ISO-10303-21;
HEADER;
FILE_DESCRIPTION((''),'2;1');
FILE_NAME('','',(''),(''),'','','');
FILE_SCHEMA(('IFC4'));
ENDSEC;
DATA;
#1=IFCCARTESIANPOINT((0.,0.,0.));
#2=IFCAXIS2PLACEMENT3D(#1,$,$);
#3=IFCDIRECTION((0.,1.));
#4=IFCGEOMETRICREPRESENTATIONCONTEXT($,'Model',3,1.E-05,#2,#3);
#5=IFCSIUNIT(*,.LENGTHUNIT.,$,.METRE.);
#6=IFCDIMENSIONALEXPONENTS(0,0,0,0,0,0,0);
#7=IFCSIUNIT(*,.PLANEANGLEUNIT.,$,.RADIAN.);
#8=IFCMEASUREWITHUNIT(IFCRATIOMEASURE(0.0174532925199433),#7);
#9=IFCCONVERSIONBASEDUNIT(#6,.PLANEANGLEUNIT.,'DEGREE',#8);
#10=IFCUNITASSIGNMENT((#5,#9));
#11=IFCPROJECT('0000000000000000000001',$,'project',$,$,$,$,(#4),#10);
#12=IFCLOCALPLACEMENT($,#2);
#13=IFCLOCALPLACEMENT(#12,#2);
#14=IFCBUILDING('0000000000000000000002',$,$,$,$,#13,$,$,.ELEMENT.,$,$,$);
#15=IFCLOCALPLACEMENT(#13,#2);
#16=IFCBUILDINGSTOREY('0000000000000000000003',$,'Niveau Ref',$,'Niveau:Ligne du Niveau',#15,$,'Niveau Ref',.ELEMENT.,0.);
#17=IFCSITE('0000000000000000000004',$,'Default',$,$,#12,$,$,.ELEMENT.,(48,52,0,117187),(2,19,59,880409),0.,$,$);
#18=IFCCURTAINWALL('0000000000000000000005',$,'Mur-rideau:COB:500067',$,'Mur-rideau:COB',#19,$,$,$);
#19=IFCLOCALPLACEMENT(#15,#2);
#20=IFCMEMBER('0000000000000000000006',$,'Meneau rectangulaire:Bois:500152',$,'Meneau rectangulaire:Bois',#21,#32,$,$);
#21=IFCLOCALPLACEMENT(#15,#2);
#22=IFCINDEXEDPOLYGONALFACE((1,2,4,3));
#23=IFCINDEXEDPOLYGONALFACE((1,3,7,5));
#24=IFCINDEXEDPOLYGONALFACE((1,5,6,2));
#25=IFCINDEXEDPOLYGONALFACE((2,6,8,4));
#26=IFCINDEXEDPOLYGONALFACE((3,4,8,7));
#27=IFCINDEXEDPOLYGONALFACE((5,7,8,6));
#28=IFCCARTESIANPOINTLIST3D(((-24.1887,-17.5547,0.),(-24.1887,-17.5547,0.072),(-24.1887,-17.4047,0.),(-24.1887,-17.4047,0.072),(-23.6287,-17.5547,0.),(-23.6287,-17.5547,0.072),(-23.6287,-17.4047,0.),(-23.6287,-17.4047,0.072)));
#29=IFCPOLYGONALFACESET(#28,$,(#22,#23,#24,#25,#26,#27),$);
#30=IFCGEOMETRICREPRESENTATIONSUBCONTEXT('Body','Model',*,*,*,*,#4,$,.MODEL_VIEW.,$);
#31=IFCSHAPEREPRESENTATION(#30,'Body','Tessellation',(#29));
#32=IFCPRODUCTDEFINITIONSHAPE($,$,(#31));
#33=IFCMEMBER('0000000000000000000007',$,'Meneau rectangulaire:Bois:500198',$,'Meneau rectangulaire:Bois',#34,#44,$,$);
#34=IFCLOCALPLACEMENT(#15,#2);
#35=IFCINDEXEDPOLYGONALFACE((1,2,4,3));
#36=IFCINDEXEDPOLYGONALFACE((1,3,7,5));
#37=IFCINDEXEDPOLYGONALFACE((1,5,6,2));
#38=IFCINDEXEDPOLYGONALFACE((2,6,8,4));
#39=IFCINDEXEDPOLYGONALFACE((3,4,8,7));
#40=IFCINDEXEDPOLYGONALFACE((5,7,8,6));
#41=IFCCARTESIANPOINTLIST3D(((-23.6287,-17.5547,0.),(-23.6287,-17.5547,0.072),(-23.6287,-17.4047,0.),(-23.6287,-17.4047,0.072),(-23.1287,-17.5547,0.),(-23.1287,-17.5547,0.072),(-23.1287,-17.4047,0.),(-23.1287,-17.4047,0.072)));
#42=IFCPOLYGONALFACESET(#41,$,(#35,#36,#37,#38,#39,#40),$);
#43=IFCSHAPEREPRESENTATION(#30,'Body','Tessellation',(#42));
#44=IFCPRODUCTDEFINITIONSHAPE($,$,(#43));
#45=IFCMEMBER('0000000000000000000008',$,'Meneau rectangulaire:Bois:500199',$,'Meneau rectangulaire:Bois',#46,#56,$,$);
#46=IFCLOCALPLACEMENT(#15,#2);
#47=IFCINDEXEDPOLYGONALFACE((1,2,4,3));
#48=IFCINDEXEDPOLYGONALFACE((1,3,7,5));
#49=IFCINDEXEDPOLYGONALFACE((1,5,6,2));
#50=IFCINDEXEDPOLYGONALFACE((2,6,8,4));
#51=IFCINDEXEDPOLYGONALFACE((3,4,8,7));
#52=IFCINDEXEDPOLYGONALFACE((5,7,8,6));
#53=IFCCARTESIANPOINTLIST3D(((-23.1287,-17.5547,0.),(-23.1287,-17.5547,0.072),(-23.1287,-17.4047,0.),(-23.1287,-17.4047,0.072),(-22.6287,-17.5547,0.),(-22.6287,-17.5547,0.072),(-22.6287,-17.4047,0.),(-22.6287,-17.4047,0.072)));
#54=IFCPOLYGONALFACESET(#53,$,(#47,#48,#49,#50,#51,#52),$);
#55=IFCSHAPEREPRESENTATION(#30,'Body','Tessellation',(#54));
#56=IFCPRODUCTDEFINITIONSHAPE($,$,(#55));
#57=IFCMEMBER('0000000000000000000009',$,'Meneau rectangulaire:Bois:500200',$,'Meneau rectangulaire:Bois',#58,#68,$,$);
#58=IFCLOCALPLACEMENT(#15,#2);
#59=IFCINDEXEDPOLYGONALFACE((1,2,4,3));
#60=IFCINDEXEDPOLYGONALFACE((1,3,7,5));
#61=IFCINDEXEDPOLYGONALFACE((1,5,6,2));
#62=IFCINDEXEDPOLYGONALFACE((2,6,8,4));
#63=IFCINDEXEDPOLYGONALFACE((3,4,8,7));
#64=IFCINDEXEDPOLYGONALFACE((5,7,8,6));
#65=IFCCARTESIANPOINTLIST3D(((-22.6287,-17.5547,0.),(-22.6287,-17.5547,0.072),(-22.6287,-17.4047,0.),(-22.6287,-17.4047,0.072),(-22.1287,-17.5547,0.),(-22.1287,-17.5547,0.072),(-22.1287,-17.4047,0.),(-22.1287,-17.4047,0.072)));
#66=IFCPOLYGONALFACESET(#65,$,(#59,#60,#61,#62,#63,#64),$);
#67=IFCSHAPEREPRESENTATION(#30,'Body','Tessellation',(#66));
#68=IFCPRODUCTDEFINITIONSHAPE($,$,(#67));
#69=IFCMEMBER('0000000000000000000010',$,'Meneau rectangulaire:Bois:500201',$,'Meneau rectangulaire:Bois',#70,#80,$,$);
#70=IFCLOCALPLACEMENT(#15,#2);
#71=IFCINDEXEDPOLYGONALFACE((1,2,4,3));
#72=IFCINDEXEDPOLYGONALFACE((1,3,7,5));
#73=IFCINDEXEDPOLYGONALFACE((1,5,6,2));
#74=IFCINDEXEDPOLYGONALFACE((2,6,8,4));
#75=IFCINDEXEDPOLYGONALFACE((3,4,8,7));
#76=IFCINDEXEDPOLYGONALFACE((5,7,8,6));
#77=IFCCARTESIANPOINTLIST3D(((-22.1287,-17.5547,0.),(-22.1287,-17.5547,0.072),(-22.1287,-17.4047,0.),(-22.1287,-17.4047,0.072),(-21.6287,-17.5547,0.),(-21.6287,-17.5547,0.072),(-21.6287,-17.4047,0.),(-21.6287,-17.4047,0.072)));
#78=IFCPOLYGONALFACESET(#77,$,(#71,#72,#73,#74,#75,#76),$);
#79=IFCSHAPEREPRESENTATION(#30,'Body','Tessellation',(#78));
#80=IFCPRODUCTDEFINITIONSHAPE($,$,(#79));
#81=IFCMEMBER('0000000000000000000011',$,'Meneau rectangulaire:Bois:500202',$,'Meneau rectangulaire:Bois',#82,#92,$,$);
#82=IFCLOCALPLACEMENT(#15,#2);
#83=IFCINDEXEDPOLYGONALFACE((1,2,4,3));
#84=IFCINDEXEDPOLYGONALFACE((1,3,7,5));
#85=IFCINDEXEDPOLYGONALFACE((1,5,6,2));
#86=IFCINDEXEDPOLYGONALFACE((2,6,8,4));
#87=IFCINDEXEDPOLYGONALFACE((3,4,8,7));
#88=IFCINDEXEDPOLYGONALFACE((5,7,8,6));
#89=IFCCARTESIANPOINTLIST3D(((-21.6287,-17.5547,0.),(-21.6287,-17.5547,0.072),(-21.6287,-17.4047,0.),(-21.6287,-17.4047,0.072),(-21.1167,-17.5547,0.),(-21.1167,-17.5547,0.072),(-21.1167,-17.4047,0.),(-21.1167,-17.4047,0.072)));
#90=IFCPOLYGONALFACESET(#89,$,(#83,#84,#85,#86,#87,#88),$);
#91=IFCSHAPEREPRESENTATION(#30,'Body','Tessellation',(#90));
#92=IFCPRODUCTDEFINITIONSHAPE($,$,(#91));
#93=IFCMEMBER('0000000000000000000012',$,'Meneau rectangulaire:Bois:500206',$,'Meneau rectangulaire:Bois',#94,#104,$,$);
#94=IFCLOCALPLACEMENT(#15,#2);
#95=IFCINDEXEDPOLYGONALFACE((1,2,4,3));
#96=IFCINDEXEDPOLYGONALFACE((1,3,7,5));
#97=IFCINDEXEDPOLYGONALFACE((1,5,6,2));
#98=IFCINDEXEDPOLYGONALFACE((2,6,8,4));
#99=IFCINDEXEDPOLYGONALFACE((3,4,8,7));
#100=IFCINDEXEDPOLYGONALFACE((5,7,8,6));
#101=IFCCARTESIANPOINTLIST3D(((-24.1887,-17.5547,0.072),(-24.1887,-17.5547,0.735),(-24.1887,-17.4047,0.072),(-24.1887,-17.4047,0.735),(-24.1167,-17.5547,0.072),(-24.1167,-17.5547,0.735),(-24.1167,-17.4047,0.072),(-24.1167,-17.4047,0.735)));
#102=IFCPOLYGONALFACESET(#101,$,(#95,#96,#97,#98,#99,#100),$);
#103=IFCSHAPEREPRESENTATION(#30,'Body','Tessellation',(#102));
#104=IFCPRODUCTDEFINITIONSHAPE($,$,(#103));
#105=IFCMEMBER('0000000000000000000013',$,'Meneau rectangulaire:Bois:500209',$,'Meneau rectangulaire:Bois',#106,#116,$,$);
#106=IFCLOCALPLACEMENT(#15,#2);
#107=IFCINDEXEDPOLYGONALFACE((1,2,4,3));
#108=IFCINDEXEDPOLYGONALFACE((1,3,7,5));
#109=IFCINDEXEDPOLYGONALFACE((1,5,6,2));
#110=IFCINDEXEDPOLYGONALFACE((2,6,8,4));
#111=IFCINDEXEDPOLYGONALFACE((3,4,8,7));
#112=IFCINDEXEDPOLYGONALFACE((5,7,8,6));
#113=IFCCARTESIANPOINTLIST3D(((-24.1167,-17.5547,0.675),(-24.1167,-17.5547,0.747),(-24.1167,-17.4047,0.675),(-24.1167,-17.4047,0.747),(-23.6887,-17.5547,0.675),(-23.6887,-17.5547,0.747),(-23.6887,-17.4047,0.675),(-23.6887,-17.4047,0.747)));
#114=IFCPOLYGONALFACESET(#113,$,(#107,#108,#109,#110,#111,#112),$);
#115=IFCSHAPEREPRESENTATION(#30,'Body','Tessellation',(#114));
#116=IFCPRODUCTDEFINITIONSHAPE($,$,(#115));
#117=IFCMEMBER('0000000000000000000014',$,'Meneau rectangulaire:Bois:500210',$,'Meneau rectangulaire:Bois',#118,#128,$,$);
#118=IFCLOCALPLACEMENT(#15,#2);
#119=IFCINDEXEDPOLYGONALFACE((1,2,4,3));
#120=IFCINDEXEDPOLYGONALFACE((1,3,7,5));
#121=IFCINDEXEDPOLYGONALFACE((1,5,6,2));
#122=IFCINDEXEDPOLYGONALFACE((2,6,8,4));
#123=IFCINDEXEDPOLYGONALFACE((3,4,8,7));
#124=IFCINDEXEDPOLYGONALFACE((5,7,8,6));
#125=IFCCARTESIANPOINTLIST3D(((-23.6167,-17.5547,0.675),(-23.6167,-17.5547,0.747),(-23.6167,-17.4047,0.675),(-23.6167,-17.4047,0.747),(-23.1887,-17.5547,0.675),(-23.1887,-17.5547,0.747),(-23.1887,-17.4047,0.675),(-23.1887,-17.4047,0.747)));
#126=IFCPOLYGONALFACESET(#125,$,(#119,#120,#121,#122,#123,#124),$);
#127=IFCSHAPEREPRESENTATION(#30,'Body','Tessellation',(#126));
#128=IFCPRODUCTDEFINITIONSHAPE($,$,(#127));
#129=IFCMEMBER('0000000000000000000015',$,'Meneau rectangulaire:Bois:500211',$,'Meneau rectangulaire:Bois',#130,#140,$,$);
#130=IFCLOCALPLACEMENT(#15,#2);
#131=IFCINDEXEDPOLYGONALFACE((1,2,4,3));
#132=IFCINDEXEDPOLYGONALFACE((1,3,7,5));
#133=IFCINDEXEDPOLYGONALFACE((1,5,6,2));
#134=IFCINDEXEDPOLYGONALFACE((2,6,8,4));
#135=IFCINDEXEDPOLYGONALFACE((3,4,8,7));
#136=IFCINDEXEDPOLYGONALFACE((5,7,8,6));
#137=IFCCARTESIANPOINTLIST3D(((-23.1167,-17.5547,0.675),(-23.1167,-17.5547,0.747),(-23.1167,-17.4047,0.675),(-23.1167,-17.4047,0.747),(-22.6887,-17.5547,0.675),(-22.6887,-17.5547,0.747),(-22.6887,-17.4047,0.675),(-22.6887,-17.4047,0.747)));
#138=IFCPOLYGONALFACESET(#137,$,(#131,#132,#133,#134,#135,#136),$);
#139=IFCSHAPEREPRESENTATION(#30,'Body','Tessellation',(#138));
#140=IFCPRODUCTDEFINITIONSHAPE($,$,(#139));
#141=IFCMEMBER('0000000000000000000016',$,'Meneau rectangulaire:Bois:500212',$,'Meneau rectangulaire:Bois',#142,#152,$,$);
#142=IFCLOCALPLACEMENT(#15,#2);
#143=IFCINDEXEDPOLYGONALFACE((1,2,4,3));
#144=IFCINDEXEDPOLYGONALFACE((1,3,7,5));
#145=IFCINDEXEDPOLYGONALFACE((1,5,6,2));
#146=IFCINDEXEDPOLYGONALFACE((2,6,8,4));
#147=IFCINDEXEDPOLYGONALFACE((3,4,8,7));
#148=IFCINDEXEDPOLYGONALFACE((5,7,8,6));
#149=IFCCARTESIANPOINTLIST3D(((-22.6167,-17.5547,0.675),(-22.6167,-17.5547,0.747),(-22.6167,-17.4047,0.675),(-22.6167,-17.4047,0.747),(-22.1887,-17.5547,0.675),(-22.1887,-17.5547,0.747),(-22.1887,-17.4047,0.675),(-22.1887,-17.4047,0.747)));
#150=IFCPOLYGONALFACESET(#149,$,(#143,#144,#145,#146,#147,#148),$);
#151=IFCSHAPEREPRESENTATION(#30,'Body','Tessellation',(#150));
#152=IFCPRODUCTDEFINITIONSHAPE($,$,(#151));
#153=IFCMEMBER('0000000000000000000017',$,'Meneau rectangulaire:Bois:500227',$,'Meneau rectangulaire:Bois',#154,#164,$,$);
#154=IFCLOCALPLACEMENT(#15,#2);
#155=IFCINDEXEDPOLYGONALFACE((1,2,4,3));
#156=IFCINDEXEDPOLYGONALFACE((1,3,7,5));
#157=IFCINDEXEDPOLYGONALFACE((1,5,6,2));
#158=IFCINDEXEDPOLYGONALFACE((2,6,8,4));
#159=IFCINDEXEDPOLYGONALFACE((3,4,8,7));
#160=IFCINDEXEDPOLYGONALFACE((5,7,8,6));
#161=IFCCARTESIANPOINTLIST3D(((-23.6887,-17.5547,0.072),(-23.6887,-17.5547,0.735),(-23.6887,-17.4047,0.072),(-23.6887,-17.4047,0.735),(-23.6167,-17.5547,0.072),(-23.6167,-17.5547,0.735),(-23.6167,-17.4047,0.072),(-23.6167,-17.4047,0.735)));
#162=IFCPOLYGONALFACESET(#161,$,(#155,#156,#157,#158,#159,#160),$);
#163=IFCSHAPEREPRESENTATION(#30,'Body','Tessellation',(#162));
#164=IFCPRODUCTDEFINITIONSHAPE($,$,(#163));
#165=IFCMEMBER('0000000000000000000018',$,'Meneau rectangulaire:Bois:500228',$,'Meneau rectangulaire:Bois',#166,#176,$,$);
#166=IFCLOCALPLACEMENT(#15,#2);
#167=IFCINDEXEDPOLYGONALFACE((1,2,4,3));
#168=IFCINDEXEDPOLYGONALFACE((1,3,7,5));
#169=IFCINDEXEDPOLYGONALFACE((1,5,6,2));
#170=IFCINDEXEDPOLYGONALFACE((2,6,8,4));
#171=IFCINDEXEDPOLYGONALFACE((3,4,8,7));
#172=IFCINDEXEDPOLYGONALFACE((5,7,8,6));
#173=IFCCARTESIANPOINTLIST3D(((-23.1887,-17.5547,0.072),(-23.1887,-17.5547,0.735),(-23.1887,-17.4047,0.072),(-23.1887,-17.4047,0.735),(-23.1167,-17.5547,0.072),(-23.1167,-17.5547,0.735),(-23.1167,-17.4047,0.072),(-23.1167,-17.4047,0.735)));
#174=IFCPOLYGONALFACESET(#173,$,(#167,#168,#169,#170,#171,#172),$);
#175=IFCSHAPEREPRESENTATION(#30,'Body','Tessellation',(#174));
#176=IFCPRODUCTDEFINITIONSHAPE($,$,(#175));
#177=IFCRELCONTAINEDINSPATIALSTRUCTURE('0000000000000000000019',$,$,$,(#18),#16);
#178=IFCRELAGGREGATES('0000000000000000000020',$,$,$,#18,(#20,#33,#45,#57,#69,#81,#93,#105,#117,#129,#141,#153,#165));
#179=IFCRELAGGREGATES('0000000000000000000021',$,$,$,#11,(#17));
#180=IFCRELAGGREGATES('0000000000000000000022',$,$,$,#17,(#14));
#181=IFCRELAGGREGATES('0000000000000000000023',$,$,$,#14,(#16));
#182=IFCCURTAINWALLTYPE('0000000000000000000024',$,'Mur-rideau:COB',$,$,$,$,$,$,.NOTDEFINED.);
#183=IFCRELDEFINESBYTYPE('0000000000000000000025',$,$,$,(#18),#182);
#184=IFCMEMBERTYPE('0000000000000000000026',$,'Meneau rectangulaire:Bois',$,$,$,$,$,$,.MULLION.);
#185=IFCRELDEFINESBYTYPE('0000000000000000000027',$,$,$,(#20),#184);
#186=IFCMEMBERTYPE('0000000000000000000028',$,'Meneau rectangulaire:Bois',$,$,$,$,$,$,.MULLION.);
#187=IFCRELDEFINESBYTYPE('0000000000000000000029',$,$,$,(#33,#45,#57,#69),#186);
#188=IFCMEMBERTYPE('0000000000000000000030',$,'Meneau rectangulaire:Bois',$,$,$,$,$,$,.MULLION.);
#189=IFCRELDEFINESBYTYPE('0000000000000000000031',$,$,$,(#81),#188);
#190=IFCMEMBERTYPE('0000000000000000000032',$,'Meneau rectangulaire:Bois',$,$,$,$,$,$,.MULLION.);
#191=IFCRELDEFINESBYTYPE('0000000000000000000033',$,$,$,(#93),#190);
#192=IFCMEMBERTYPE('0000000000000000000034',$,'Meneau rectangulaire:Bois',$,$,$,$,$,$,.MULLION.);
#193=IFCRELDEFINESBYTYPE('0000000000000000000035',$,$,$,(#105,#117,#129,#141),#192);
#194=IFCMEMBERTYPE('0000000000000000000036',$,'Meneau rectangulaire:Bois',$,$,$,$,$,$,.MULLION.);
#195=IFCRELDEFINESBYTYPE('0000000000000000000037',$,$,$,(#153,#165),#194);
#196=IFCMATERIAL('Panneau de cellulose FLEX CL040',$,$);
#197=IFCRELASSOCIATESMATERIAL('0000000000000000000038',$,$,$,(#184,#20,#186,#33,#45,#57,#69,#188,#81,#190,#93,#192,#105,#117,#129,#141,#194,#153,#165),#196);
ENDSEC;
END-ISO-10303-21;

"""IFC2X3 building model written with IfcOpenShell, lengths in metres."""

from ifc_helpers import new_model, entity, si_unit, converted_unit, direction, frame, origin, origin_2d_with_axis, place, context, subcontext, project, spatial, rectangle, extrude, source, transform, mapped, material, type_object, type_shapes, element, aggregate, save


model = new_model("IFC2X3")

# Units and contexts
model_context = context("Model", 3, precision=1e-05, world=origin(), true_north=direction((0.0, 1.0)))
body_context = subcontext(model_context, "Body", "Model", "MODEL_VIEW")
ifc_project = project(units=[si_unit("LENGTHUNIT", "METRE"), converted_unit("PLANEANGLEUNIT", "DEGREE", entity("IfcRatioMeasure", 0.0174532925199433), si_unit("PLANEANGLEUNIT", "RADIAN"), dimensions=[0, 0, 0, 0, 0, 0, 0])], contexts=[model_context])

# Site, building, storey
site_placement = place(None, origin())
site = spatial("IfcSite", under=ifc_project, at=site_placement, Name="Default", CompositionType="ELEMENT", RefLatitude=(48, 52, 0, 117187), RefLongitude=(2, 19, 59, 880409), RefElevation=0.0)
building_placement = place(site_placement, origin())
building = spatial("IfcBuilding", under=site, at=building_placement, CompositionType="ELEMENT")
storey_placement = place(building_placement, origin())
storey = spatial("IfcBuildingStorey", under=building, at=storey_placement, Name="Niveau Ref", ObjectType="Niveau:Ligne du Niveau", LongName="Niveau Ref", CompositionType="ELEMENT", Elevation=0.0)

# Curtain wall, members
curtain_wall_type_1 = type_object("IfcCurtainWallType", Name="Mur-rideau:COB", PredefinedType="NOTDEFINED")
curtain_wall_1_placement = place(storey_placement, origin())
curtain_wall_1 = element("IfcCurtainWall", 1, at=curtain_wall_1_placement, inside=storey, type_object=curtain_wall_type_1, Name="Mur-rideau:COB:500067", ObjectType="Mur-rideau:COB")
ifc_material_1 = material(Name="Panneau de cellulose FLEX CL040")
member_type_1 = type_object("IfcMemberType", Name="Meneau rectangulaire:Bois", PredefinedType="MULLION", material=ifc_material_1)
shared_shape_1 = source(origin(), body_context, "Body", "SweptSolid", [
    extrude(rectangle(XDim=0.15, YDim=0.072, at=origin_2d_with_axis()), frame((-0.036, 0.0, -0.56), z_axis=(0.0, 0.0, 1.0), x_axis=(0.0, -1.0, 0.0)), (0.0, 0.0, 1.0), 0.56),
])
type_shapes(member_type_1, [shared_shape_1])
member_1_placement = place(storey_placement, frame((-24.1887, -17.4797, 0.0), z_axis=(-1.0, 0.0, 0.0), x_axis=(0.0, 0.0, -1.0)))
member_1 = element("IfcMember", 2, at=member_1_placement, type_object=member_type_1, material=ifc_material_1, Name="Meneau rectangulaire:Bois:500152", ObjectType="Meneau rectangulaire:Bois", context=body_context, shape_type="MappedRepresentation", body=[
    mapped(shared_shape_1, transform((0.0, 0.0, 0.0), scale=1.0)),
])
member_type_2 = type_object("IfcMemberType", Name="Meneau rectangulaire:Bois", PredefinedType="MULLION", material=ifc_material_1)
shared_shape_2 = source(origin(), body_context, "Body", "SweptSolid", [
    extrude(rectangle(XDim=0.15, YDim=0.072, at=origin_2d_with_axis()), frame((-0.036, 0.0, -0.5), z_axis=(0.0, 0.0, 1.0), x_axis=(0.0, -1.0, 0.0)), (0.0, 0.0, 1.0), 0.5),
])
type_shapes(member_type_2, [shared_shape_2])
member_2_placement = place(storey_placement, frame((-23.6287, -17.4797, 0.0), z_axis=(-1.0, 0.0, 0.0), x_axis=(0.0, 0.0, -1.0)))
member_2 = element("IfcMember", 3, at=member_2_placement, type_object=member_type_2, material=ifc_material_1, Name="Meneau rectangulaire:Bois:500198", ObjectType="Meneau rectangulaire:Bois", context=body_context, shape_type="MappedRepresentation", body=[
    mapped(shared_shape_2, transform((0.0, 0.0, 0.0), scale=1.0)),
])
member_3_placement = place(storey_placement, frame((-23.1287, -17.4797, 0.0), z_axis=(-1.0, 0.0, 0.0), x_axis=(0.0, 0.0, -1.0)))
member_3 = element("IfcMember", 4, at=member_3_placement, type_object=member_type_2, material=ifc_material_1, Name="Meneau rectangulaire:Bois:500199", ObjectType="Meneau rectangulaire:Bois", context=body_context, shape_type="MappedRepresentation", body=[
    mapped(shared_shape_2, transform((0.0, 0.0, 0.0), scale=1.0)),
])
member_4_placement = place(storey_placement, frame((-22.6287, -17.4797, 0.0), z_axis=(-1.0, 0.0, 0.0), x_axis=(0.0, 0.0, -1.0)))
member_4 = element("IfcMember", 5, at=member_4_placement, type_object=member_type_2, material=ifc_material_1, Name="Meneau rectangulaire:Bois:500200", ObjectType="Meneau rectangulaire:Bois", context=body_context, shape_type="MappedRepresentation", body=[
    mapped(shared_shape_2, transform((0.0, 0.0, 0.0), scale=1.0)),
])
member_5_placement = place(storey_placement, frame((-22.1287, -17.4797, 0.0), z_axis=(-1.0, 0.0, 0.0), x_axis=(0.0, 0.0, -1.0)))
member_5 = element("IfcMember", 6, at=member_5_placement, type_object=member_type_2, material=ifc_material_1, Name="Meneau rectangulaire:Bois:500201", ObjectType="Meneau rectangulaire:Bois", context=body_context, shape_type="MappedRepresentation", body=[
    mapped(shared_shape_2, transform((0.0, 0.0, 0.0), scale=1.0)),
])
member_type_3 = type_object("IfcMemberType", Name="Meneau rectangulaire:Bois", PredefinedType="MULLION", material=ifc_material_1)
shared_shape_3 = source(origin(), body_context, "Body", "SweptSolid", [
    extrude(rectangle(XDim=0.15, YDim=0.072, at=origin_2d_with_axis()), frame((-0.036, 0.0, -0.512), z_axis=(0.0, 0.0, 1.0), x_axis=(0.0, -1.0, 0.0)), (0.0, 0.0, 1.0), 0.512),
])
type_shapes(member_type_3, [shared_shape_3])
member_6_placement = place(storey_placement, frame((-21.6287, -17.4797, 0.0), z_axis=(-1.0, 0.0, 0.0), x_axis=(0.0, 0.0, -1.0)))
member_6 = element("IfcMember", 7, at=member_6_placement, type_object=member_type_3, material=ifc_material_1, Name="Meneau rectangulaire:Bois:500202", ObjectType="Meneau rectangulaire:Bois", context=body_context, shape_type="MappedRepresentation", body=[
    mapped(shared_shape_3, transform((0.0, 0.0, 0.0), scale=1.0)),
])
member_type_4 = type_object("IfcMemberType", Name="Meneau rectangulaire:Bois", PredefinedType="MULLION", material=ifc_material_1)
shared_shape_4 = source(origin(), body_context, "Body", "SweptSolid", [
    extrude(rectangle(XDim=0.15, YDim=0.072, at=origin_2d_with_axis()), frame((-0.036, 0.0, -0.663), z_axis=(0.0, 0.0, 1.0), x_axis=(0.0, -1.0, 0.0)), (0.0, 0.0, 1.0), 0.663),
])
type_shapes(member_type_4, [shared_shape_4])
member_7_placement = place(storey_placement, frame((-24.1887, -17.4797, 0.735), z_axis=(0.0, 0.0, 1.0), x_axis=(-1.0, 0.0, 0.0)))
member_7 = element("IfcMember", 8, at=member_7_placement, type_object=member_type_4, material=ifc_material_1, Name="Meneau rectangulaire:Bois:500206", ObjectType="Meneau rectangulaire:Bois", context=body_context, shape_type="MappedRepresentation", body=[
    mapped(shared_shape_4, transform((0.0, 0.0, 0.0), scale=1.0)),
])
member_type_5 = type_object("IfcMemberType", Name="Meneau rectangulaire:Bois", PredefinedType="MULLION", material=ifc_material_1)
shared_shape_5 = source(origin(), body_context, "Body", "SweptSolid", [
    extrude(rectangle(XDim=0.15, YDim=0.072, at=origin_2d_with_axis()), frame((-0.024, 0.0, -0.428), z_axis=(0.0, 0.0, 1.0), x_axis=(0.0, -1.0, 0.0)), (0.0, 0.0, 1.0), 0.428),
])
type_shapes(member_type_5, [shared_shape_5])
member_8_placement = place(storey_placement, frame((-23.6887, -17.4797, 0.735), z_axis=(1.0, 0.0, 0.0), x_axis=(0.0, 0.0, 1.0)))
member_8 = element("IfcMember", 9, at=member_8_placement, type_object=member_type_5, material=ifc_material_1, Name="Meneau rectangulaire:Bois:500209", ObjectType="Meneau rectangulaire:Bois", context=body_context, shape_type="MappedRepresentation", body=[
    mapped(shared_shape_5, transform((0.0, 0.0, 0.0), scale=1.0)),
])
member_9_placement = place(storey_placement, frame((-23.1887, -17.4797, 0.735), z_axis=(1.0, 0.0, 0.0), x_axis=(0.0, 0.0, 1.0)))
member_9 = element("IfcMember", 10, at=member_9_placement, type_object=member_type_5, material=ifc_material_1, Name="Meneau rectangulaire:Bois:500210", ObjectType="Meneau rectangulaire:Bois", context=body_context, shape_type="MappedRepresentation", body=[
    mapped(shared_shape_5, transform((0.0, 0.0, 0.0), scale=1.0)),
])
member_10_placement = place(storey_placement, frame((-22.6887, -17.4797, 0.735), z_axis=(1.0, 0.0, 0.0), x_axis=(0.0, 0.0, 1.0)))
member_10 = element("IfcMember", 11, at=member_10_placement, type_object=member_type_5, material=ifc_material_1, Name="Meneau rectangulaire:Bois:500211", ObjectType="Meneau rectangulaire:Bois", context=body_context, shape_type="MappedRepresentation", body=[
    mapped(shared_shape_5, transform((0.0, 0.0, 0.0), scale=1.0)),
])
member_11_placement = place(storey_placement, frame((-22.1887, -17.4797, 0.735), z_axis=(1.0, 0.0, 0.0), x_axis=(0.0, 0.0, 1.0)))
member_11 = element("IfcMember", 12, at=member_11_placement, type_object=member_type_5, material=ifc_material_1, Name="Meneau rectangulaire:Bois:500212", ObjectType="Meneau rectangulaire:Bois", context=body_context, shape_type="MappedRepresentation", body=[
    mapped(shared_shape_5, transform((0.0, 0.0, 0.0), scale=1.0)),
])
member_type_6 = type_object("IfcMemberType", Name="Meneau rectangulaire:Bois", PredefinedType="MULLION", material=ifc_material_1)
shared_shape_6 = source(origin(), body_context, "Body", "SweptSolid", [
    extrude(rectangle(XDim=0.15, YDim=0.072, at=origin_2d_with_axis()), frame((-0.024, 0.0, -0.663), z_axis=(0.0, 0.0, 1.0), x_axis=(0.0, -1.0, 0.0)), (0.0, 0.0, 1.0), 0.663),
])
type_shapes(member_type_6, [shared_shape_6])
member_12_placement = place(storey_placement, frame((-23.6287, -17.4797, 0.072), z_axis=(0.0, 0.0, -1.0), x_axis=(1.0, 0.0, 0.0)))
member_12 = element("IfcMember", 13, at=member_12_placement, type_object=member_type_6, material=ifc_material_1, Name="Meneau rectangulaire:Bois:500227", ObjectType="Meneau rectangulaire:Bois", context=body_context, shape_type="MappedRepresentation", body=[
    mapped(shared_shape_6, transform((0.0, 0.0, 0.0), scale=1.0)),
])
member_13_placement = place(storey_placement, frame((-23.1287, -17.4797, 0.072), z_axis=(0.0, 0.0, -1.0), x_axis=(1.0, 0.0, 0.0)))
member_13 = element("IfcMember", 14, at=member_13_placement, type_object=member_type_6, material=ifc_material_1, Name="Meneau rectangulaire:Bois:500228", ObjectType="Meneau rectangulaire:Bois", context=body_context, shape_type="MappedRepresentation", body=[
    mapped(shared_shape_6, transform((0.0, 0.0, 0.0), scale=1.0)),
])
aggregate(curtain_wall_1, [member_1, member_2, member_3, member_4, member_5, member_6, member_7, member_8, member_9, member_10, member_11, member_12, member_13])

save(model, "model.ifc")
